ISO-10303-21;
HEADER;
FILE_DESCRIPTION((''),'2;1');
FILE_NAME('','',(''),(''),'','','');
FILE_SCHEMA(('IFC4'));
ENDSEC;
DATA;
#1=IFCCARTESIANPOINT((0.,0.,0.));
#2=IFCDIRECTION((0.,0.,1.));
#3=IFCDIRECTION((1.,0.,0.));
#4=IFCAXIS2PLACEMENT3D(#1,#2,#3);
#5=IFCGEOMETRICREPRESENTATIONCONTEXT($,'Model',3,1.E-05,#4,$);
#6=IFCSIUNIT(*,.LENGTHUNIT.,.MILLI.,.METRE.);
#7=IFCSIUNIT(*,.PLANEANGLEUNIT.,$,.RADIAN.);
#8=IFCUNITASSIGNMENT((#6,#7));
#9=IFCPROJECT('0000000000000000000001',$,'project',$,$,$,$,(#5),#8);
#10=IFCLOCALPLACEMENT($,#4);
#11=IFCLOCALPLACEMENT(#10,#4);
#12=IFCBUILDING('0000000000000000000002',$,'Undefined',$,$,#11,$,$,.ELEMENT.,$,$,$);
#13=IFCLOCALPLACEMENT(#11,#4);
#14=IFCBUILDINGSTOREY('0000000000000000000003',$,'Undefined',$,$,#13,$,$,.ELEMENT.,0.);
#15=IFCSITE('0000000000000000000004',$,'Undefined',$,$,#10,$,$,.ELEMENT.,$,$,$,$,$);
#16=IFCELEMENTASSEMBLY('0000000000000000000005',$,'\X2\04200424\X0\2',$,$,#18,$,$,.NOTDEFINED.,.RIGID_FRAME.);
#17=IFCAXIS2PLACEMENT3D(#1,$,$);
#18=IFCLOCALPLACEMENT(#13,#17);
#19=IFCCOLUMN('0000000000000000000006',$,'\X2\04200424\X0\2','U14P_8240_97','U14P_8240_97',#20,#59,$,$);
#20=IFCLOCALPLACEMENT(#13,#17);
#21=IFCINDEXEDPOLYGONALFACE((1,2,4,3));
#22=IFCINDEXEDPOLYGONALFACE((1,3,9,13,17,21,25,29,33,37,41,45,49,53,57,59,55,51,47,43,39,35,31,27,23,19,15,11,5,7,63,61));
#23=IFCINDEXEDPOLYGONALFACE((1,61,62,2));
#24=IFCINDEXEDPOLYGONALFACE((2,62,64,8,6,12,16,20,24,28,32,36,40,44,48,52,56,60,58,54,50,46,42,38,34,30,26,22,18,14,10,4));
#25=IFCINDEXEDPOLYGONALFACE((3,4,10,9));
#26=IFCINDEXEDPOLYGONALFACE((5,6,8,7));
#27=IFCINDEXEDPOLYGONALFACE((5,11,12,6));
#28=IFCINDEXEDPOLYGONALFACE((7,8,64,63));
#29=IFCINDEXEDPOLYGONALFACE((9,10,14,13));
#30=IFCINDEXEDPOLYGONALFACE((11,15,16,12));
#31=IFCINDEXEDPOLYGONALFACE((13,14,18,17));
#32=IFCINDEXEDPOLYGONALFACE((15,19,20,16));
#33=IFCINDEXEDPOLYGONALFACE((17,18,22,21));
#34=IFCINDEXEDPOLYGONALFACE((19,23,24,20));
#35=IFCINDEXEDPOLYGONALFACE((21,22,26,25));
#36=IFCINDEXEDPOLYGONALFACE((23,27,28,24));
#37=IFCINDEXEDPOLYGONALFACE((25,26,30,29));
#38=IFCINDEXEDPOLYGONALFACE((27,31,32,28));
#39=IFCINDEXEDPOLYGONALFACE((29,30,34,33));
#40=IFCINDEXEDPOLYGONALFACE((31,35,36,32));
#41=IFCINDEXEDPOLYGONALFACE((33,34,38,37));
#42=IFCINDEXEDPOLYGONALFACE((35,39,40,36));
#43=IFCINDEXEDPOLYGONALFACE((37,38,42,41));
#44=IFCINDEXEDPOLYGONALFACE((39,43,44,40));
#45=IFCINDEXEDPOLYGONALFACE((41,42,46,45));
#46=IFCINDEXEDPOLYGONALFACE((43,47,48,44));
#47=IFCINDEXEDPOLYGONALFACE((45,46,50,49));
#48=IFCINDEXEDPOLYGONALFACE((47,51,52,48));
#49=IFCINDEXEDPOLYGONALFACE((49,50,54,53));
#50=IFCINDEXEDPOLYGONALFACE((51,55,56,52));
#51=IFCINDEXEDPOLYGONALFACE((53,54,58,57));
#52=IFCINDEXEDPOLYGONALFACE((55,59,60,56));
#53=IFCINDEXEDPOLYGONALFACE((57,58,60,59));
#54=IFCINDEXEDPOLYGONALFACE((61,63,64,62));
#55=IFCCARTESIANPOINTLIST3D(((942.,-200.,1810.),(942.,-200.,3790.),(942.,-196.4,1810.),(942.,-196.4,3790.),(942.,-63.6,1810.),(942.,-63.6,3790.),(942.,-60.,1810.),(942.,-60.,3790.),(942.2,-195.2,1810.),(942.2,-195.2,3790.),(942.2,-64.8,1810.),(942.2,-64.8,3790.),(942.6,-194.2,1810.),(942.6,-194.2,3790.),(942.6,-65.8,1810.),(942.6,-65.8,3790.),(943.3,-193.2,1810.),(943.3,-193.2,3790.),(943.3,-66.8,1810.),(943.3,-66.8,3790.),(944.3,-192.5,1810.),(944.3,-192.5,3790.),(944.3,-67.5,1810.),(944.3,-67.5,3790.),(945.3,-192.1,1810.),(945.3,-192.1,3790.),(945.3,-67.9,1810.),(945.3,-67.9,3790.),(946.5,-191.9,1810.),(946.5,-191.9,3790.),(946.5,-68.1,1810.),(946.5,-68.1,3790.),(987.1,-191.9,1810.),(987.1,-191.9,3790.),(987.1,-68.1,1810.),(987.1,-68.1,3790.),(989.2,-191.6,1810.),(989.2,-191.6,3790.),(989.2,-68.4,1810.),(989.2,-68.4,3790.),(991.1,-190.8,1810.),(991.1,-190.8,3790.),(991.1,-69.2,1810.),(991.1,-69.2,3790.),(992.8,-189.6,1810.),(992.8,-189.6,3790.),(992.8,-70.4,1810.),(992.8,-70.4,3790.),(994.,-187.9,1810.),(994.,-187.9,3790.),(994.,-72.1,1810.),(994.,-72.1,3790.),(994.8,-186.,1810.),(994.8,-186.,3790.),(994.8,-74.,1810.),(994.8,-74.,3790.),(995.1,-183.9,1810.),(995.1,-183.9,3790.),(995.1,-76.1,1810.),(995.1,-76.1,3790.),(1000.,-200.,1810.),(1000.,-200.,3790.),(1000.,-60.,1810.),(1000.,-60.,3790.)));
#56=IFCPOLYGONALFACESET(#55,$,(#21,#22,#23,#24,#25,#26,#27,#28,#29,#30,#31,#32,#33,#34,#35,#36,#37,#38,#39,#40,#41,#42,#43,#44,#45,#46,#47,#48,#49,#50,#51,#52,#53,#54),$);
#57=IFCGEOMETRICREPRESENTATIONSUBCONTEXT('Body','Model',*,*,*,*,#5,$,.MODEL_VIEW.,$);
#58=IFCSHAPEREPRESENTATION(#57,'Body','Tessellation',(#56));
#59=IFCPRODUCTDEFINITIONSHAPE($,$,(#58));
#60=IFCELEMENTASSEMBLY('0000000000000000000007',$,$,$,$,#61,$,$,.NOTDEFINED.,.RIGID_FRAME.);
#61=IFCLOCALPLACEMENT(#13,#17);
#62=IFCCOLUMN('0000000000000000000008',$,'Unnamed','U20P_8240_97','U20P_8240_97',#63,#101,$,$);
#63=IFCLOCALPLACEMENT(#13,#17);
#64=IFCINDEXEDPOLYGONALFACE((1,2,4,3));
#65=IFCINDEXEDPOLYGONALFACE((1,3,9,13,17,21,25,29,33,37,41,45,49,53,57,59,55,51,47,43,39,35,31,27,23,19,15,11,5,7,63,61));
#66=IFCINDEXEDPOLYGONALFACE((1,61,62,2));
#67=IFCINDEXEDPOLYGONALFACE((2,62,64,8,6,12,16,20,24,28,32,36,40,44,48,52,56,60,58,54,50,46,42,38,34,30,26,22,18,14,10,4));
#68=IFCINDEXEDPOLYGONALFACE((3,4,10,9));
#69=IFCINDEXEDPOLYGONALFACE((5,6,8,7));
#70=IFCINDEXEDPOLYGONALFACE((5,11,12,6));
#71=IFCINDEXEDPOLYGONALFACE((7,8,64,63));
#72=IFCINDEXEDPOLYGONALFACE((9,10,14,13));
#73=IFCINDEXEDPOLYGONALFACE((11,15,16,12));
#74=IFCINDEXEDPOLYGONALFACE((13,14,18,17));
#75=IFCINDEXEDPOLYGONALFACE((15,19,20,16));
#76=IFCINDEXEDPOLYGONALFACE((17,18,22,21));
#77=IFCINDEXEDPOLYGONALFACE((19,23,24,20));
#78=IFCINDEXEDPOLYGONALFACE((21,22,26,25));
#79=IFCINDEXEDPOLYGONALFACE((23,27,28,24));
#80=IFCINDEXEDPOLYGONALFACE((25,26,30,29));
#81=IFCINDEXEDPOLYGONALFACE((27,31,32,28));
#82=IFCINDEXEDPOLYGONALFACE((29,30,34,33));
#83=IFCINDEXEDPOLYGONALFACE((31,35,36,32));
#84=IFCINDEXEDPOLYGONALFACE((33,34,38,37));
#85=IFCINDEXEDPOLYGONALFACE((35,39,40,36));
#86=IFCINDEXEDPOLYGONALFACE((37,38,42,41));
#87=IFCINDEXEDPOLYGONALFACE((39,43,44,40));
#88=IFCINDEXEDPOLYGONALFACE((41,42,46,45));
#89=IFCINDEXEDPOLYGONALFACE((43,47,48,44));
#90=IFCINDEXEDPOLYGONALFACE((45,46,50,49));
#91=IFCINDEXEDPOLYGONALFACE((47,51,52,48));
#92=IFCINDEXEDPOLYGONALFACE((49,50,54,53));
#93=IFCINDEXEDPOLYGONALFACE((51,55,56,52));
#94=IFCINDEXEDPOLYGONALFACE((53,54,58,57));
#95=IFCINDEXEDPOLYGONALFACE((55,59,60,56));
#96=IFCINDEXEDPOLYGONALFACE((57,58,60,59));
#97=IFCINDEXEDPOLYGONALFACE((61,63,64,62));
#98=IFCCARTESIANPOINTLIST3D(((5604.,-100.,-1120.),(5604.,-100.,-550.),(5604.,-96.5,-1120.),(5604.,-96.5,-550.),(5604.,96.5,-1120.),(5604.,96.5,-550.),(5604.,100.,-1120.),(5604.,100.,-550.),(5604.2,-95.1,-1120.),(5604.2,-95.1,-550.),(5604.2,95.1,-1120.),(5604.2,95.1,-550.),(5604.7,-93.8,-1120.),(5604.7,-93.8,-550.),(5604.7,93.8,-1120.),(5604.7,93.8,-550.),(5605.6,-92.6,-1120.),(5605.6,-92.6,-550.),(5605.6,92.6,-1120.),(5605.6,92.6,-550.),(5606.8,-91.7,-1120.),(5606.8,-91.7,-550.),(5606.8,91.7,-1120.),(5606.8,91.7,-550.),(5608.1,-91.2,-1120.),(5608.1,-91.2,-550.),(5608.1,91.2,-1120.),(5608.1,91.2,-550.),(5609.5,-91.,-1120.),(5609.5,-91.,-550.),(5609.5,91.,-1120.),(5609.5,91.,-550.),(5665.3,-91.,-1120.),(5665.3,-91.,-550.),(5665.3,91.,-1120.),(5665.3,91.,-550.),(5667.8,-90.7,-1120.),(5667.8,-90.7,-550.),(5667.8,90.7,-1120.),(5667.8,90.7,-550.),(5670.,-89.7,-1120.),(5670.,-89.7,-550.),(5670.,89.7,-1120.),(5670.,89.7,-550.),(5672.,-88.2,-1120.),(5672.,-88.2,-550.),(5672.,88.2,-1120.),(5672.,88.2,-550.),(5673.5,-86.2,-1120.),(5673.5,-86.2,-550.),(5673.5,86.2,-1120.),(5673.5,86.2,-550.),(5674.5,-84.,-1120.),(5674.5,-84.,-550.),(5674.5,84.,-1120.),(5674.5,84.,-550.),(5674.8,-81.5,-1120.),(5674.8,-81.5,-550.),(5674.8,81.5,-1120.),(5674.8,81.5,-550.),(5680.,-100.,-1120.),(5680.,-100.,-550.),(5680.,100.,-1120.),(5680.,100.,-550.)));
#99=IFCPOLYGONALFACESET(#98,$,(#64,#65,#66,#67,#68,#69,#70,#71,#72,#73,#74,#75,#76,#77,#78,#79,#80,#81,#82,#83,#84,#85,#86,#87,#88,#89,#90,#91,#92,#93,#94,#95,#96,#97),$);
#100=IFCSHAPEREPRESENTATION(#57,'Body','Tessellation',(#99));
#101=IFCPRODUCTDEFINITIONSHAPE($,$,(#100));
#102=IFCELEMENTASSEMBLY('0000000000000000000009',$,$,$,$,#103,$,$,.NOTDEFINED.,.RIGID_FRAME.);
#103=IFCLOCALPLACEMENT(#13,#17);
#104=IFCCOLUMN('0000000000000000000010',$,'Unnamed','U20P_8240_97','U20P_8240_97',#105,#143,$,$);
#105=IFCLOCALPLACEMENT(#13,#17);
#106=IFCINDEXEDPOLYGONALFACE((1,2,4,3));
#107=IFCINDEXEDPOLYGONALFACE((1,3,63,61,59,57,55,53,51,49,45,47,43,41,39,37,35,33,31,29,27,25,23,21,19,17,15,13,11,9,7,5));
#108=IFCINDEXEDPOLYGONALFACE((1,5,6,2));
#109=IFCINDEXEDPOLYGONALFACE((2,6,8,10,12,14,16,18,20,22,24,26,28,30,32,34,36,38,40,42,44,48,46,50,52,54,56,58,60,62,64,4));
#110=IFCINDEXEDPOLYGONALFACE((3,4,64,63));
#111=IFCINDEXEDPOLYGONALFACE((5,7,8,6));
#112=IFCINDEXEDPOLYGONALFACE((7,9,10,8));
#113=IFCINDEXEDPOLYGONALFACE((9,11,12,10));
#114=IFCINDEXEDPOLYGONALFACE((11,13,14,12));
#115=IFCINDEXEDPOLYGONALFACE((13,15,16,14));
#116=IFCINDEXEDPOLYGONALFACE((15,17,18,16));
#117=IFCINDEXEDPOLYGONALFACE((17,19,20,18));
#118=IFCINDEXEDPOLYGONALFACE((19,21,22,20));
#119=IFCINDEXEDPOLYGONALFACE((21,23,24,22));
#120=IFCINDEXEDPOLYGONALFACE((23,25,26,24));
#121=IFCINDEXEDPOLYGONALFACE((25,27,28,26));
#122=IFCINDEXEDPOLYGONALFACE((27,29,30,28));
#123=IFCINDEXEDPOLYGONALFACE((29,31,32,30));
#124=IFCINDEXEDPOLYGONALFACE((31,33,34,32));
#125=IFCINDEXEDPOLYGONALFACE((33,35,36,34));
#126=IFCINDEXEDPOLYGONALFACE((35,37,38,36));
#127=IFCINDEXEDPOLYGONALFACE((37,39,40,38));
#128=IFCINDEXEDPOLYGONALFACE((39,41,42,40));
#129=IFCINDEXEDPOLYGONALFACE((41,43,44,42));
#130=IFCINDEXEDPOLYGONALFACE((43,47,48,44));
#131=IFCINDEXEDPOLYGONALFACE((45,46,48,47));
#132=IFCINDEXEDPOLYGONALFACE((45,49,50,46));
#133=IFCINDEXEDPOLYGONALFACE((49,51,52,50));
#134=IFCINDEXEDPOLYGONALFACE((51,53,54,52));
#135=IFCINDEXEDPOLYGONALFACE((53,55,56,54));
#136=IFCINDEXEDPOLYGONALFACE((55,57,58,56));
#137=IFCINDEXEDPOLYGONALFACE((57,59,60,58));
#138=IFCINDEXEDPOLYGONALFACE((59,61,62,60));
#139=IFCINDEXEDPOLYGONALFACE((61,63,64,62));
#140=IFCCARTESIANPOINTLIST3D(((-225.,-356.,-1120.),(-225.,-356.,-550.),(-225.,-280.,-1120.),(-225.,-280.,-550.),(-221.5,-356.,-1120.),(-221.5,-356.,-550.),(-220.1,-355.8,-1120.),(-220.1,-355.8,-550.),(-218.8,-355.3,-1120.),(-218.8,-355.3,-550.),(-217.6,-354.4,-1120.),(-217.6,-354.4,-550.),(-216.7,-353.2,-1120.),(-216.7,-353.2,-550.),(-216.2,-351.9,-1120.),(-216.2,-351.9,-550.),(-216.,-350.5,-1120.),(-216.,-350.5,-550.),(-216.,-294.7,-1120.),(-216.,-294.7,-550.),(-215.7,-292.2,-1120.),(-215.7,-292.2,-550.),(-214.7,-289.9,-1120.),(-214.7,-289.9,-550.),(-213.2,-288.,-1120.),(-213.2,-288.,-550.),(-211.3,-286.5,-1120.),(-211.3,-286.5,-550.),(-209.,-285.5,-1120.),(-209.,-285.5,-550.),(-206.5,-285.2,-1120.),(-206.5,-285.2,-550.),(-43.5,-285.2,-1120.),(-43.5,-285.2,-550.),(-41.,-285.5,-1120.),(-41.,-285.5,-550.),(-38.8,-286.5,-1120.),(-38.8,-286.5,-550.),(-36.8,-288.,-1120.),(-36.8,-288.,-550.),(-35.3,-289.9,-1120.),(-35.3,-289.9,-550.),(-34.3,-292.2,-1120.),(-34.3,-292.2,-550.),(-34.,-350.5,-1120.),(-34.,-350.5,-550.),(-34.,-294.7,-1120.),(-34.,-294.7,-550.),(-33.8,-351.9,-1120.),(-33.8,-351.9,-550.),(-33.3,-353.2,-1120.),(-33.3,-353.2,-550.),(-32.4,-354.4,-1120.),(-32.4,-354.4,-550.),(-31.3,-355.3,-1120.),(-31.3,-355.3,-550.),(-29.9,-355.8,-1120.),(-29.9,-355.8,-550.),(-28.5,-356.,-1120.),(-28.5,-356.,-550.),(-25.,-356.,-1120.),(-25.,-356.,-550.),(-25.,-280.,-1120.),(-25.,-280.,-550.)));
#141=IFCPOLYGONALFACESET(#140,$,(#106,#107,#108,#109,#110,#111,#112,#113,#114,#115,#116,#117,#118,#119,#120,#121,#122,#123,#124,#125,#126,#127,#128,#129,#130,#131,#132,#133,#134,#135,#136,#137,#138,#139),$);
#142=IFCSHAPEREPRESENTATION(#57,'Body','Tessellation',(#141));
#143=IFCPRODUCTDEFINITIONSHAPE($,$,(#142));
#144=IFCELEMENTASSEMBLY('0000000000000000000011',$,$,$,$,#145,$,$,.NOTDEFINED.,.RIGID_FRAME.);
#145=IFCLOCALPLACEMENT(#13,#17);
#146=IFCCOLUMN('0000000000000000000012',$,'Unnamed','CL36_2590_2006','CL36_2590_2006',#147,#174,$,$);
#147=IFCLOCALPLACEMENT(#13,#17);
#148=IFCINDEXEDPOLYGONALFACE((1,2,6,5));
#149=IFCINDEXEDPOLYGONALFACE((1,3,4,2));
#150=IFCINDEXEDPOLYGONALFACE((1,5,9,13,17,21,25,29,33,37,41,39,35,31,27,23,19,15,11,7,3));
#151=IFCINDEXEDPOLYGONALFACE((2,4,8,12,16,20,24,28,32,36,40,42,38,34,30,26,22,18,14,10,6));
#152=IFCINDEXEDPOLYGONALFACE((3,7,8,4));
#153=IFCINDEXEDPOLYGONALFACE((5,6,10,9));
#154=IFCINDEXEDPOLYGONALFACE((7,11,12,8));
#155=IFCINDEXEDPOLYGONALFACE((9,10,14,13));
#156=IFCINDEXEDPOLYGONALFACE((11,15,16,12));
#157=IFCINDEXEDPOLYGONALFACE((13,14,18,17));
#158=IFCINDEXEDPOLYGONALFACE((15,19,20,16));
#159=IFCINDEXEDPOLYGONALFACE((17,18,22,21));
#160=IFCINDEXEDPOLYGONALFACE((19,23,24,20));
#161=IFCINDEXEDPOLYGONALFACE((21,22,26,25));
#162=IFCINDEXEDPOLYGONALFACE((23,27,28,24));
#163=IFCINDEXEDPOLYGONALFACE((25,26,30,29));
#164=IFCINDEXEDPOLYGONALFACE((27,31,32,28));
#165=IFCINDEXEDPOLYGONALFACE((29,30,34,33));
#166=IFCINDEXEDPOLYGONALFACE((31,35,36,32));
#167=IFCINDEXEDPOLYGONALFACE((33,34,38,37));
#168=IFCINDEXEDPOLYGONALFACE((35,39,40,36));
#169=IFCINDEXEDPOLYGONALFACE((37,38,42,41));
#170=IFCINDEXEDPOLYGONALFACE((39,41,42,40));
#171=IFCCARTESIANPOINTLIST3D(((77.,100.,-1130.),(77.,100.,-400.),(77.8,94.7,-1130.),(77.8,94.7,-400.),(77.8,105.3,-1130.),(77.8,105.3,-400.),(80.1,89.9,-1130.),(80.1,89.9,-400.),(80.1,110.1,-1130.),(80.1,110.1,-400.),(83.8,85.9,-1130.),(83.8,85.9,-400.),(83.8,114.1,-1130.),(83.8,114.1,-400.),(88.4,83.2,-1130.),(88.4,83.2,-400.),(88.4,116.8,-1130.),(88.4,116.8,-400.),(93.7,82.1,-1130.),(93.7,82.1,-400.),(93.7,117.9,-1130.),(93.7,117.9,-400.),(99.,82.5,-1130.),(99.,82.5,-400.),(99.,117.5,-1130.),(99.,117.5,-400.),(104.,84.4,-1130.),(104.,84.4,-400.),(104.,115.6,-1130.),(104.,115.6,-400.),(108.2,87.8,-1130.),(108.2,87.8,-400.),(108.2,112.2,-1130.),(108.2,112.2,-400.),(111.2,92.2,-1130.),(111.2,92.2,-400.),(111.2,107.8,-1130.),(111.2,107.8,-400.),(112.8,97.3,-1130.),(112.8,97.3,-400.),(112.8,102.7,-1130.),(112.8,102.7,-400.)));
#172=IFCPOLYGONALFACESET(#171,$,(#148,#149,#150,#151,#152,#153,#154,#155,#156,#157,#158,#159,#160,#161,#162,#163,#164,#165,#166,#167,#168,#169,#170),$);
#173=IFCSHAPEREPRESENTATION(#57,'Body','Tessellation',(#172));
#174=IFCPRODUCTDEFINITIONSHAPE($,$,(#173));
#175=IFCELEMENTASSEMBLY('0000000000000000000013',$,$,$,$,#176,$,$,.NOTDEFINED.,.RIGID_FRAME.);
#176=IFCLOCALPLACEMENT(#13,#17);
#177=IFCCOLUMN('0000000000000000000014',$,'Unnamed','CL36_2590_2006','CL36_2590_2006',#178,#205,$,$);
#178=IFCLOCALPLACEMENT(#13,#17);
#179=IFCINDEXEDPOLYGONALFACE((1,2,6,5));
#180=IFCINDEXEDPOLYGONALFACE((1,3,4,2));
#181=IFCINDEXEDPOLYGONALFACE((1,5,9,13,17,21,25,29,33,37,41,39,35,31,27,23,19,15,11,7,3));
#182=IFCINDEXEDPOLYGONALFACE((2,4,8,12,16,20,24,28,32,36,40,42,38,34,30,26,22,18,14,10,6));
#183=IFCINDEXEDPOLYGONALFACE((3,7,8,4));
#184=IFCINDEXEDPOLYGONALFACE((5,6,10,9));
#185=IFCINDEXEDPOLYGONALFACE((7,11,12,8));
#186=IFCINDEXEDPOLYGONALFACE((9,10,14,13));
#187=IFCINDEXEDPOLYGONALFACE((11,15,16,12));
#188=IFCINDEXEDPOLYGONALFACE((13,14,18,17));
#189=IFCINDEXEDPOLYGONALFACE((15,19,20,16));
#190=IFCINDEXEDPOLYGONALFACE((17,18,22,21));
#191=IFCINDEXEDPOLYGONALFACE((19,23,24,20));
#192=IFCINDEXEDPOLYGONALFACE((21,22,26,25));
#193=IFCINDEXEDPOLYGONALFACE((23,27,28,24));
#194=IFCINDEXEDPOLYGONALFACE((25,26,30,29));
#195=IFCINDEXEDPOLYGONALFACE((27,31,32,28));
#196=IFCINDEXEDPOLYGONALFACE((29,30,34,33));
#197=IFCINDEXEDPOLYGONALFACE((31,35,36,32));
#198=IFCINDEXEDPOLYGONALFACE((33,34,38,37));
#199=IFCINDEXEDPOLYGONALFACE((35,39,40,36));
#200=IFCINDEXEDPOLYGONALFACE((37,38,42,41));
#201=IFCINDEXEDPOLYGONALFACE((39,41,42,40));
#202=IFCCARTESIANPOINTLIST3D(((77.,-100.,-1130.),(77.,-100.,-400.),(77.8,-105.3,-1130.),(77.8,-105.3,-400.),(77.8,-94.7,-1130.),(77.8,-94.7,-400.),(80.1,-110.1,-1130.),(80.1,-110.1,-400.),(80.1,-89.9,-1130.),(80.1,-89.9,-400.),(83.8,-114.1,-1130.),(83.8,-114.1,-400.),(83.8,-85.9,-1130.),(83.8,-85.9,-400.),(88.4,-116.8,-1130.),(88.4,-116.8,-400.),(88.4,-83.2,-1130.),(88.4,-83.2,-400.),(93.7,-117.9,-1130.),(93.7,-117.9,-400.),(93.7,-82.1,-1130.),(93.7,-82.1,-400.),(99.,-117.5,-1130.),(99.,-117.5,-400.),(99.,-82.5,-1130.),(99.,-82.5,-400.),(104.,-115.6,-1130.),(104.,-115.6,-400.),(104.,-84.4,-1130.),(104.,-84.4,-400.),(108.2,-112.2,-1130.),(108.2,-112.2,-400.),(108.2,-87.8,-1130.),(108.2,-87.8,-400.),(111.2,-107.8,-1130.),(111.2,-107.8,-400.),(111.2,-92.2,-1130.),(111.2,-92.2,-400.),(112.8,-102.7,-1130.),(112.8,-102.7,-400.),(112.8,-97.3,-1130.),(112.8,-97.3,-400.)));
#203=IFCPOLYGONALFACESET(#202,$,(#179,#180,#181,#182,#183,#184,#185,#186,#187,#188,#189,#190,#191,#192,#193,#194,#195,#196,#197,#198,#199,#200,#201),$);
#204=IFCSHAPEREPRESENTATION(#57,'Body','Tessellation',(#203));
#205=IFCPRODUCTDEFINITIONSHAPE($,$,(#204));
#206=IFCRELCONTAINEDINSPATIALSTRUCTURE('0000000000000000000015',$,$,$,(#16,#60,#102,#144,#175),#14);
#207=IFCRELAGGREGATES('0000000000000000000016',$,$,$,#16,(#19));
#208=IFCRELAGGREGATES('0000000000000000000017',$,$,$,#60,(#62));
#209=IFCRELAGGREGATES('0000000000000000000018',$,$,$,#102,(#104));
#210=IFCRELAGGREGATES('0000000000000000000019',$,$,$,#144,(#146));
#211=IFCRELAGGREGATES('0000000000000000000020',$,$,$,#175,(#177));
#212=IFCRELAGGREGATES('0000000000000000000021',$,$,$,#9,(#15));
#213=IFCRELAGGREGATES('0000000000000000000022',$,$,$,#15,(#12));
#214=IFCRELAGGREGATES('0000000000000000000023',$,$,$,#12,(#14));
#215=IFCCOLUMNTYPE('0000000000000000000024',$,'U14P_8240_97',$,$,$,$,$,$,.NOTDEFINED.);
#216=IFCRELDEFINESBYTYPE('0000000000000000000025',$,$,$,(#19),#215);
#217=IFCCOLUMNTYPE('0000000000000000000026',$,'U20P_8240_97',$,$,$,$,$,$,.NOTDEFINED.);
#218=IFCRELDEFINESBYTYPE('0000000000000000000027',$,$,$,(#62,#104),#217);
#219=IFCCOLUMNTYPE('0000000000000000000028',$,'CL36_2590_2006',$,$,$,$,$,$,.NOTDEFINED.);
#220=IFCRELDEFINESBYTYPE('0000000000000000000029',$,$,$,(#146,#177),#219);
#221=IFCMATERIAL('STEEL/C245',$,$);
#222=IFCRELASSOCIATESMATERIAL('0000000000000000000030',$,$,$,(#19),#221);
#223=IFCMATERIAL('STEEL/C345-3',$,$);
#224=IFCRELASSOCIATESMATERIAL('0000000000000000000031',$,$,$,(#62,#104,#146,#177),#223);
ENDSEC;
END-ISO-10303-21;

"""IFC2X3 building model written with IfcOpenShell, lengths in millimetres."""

from ifc_helpers import new_model, si_unit, frame, origin_with_axes, origin_2d_with_axis, place, context, subcontext, project, spatial, circle, u_section, extrude, material, type_object, element, aggregate, save


model = new_model("IFC2X3")

# Units and contexts
model_context = context("Model", 3, precision=1e-05, world=origin_with_axes())
body_context = subcontext(model_context, "Body", "Model", "MODEL_VIEW")
ifc_project = project(units=[si_unit("LENGTHUNIT", "METRE", prefix="MILLI"), si_unit("PLANEANGLEUNIT", "RADIAN")], contexts=[model_context])

# Site, building, storey
site_placement = place(None, origin_with_axes())
site = spatial("IfcSite", under=ifc_project, at=site_placement, Name="Undefined", CompositionType="ELEMENT")
building_placement = place(site_placement, origin_with_axes())
building = spatial("IfcBuilding", under=site, at=building_placement, Name="Undefined", CompositionType="ELEMENT")
storey_placement = place(building_placement, origin_with_axes())
storey = spatial("IfcBuildingStorey", under=building, at=storey_placement, Name="Undefined", CompositionType="ELEMENT", Elevation=0.0)

# Element assemblies, columns
ifc_material_1 = material(Name="STEEL/C345-3")
ifc_material_2 = material(Name="STEEL/C245")
column_type_1 = type_object("IfcColumnType", Name="U14P_8240_97", PredefinedType="NOTDEFINED")
assembly_1_placement = place(storey_placement, origin_with_axes())
assembly_1 = element("IfcElementAssembly", 1, at=assembly_1_placement, inside=storey, Name="РФ2", AssemblyPlace="NOTDEFINED", PredefinedType="RIGID_FRAME")
column_1_placement = place(assembly_1_placement, frame((971.0, -130.0, 1810.0), z_axis=(0.0, 0.0, 1.0), x_axis=(0.0, 1.0, 0.0)))
column_1 = element("IfcColumn", 2, at=column_1_placement, type_object=column_type_1, material=ifc_material_2, Name="РФ2", Description="U14P_8240_97", ObjectType="U14P_8240_97", context=body_context, shape_type="SweptSolid", body=[
    extrude(u_section(Depth=140.0, FlangeWidth=58.0, WebThickness=4.9, FlangeThickness=8.1, FilletRadius=8.0, EdgeRadius=4.5, at=origin_2d_with_axis()), frame((0.0, 0.0, 1980.0), z_axis=(0.0, 0.0, -1.0), x_axis=(0.0, 1.0, 0.0)), (0.0, 0.0, 1.0), 1980.0),
])
aggregate(assembly_1, [column_1])
assembly_2_placement = place(storey_placement, origin_with_axes())
assembly_2 = element("IfcElementAssembly", 3, at=assembly_2_placement, inside=storey, AssemblyPlace="NOTDEFINED", PredefinedType="RIGID_FRAME")
column_type_2 = type_object("IfcColumnType", Name="U20P_8240_97", PredefinedType="NOTDEFINED")
column_2_placement = place(assembly_2_placement, frame((5642.0, 0.0, -1120.0), z_axis=(0.0, 0.0, 1.0), x_axis=(0.0, 1.0, 0.0)))
column_2 = element("IfcColumn", 4, at=column_2_placement, type_object=column_type_2, material=ifc_material_1, Name="Unnamed", Description="U20P_8240_97", ObjectType="U20P_8240_97", context=body_context, shape_type="SweptSolid", body=[
    extrude(u_section(Depth=200.0, FlangeWidth=76.0, WebThickness=5.2, FlangeThickness=9.0, FilletRadius=9.5, EdgeRadius=5.5, at=origin_2d_with_axis()), frame((0.0, 0.0, 570.0), z_axis=(0.0, 0.0, -1.0), x_axis=(0.0, 1.0, 0.0)), (0.0, 0.0, 1.0), 570.0),
])
aggregate(assembly_2, [column_2])
assembly_3_placement = place(storey_placement, origin_with_axes())
assembly_3 = element("IfcElementAssembly", 5, at=assembly_3_placement, inside=storey, AssemblyPlace="NOTDEFINED", PredefinedType="RIGID_FRAME")
column_3_placement = place(assembly_3_placement, frame((-125.0, -318.0, -1120.0), z_axis=(0.0, 0.0, 1.0), x_axis=(-1.0, 0.0, 0.0)))
column_3 = element("IfcColumn", 6, at=column_3_placement, type_object=column_type_2, material=ifc_material_1, Name="Unnamed", Description="U20P_8240_97", ObjectType="U20P_8240_97", context=body_context, shape_type="SweptSolid", body=[
    extrude(u_section(Depth=200.0, FlangeWidth=76.0, WebThickness=5.2, FlangeThickness=9.0, FilletRadius=9.5, EdgeRadius=5.5, at=origin_2d_with_axis()), frame((0.0, 0.0, 570.0), z_axis=(0.0, 0.0, -1.0), x_axis=(0.0, 1.0, 0.0)), (0.0, 0.0, 1.0), 570.0),
])
aggregate(assembly_3, [column_3])
assembly_4_placement = place(storey_placement, origin_with_axes())
assembly_4 = element("IfcElementAssembly", 7, at=assembly_4_placement, inside=storey, AssemblyPlace="NOTDEFINED", PredefinedType="RIGID_FRAME")
column_type_3 = type_object("IfcColumnType", Name="CL36_2590_2006", PredefinedType="NOTDEFINED")
column_4_placement = place(assembly_4_placement, frame((95.0, 100.0, -1130.0), z_axis=(0.0, 0.0, 1.0), x_axis=(0.0, 1.0, 0.0)))
column_4 = element("IfcColumn", 8, at=column_4_placement, type_object=column_type_3, material=ifc_material_1, Name="Unnamed", Description="CL36_2590_2006", ObjectType="CL36_2590_2006", context=body_context, shape_type="SweptSolid", body=[
    extrude(circle(Radius=18.0, at=origin_2d_with_axis()), frame((0.0, 0.0, 730.0), z_axis=(0.0, 0.0, -1.0), x_axis=(0.0, 1.0, 0.0)), (0.0, 0.0, 1.0), 730.0),
])
aggregate(assembly_4, [column_4])
assembly_5_placement = place(storey_placement, origin_with_axes())
assembly_5 = element("IfcElementAssembly", 9, at=assembly_5_placement, inside=storey, AssemblyPlace="NOTDEFINED", PredefinedType="RIGID_FRAME")
column_5_placement = place(assembly_5_placement, frame((95.0, -100.0, -1130.0), z_axis=(0.0, 0.0, 1.0), x_axis=(0.0, 1.0, 0.0)))
column_5 = element("IfcColumn", 10, at=column_5_placement, type_object=column_type_3, material=ifc_material_1, Name="Unnamed", Description="CL36_2590_2006", ObjectType="CL36_2590_2006", context=body_context, shape_type="SweptSolid", body=[
    extrude(circle(Radius=18.0, at=origin_2d_with_axis()), frame((0.0, 0.0, 730.0), z_axis=(0.0, 0.0, -1.0), x_axis=(0.0, 1.0, 0.0)), (0.0, 0.0, 1.0), 730.0),
])
aggregate(assembly_5, [column_5])

save(model, "model.ifc")
